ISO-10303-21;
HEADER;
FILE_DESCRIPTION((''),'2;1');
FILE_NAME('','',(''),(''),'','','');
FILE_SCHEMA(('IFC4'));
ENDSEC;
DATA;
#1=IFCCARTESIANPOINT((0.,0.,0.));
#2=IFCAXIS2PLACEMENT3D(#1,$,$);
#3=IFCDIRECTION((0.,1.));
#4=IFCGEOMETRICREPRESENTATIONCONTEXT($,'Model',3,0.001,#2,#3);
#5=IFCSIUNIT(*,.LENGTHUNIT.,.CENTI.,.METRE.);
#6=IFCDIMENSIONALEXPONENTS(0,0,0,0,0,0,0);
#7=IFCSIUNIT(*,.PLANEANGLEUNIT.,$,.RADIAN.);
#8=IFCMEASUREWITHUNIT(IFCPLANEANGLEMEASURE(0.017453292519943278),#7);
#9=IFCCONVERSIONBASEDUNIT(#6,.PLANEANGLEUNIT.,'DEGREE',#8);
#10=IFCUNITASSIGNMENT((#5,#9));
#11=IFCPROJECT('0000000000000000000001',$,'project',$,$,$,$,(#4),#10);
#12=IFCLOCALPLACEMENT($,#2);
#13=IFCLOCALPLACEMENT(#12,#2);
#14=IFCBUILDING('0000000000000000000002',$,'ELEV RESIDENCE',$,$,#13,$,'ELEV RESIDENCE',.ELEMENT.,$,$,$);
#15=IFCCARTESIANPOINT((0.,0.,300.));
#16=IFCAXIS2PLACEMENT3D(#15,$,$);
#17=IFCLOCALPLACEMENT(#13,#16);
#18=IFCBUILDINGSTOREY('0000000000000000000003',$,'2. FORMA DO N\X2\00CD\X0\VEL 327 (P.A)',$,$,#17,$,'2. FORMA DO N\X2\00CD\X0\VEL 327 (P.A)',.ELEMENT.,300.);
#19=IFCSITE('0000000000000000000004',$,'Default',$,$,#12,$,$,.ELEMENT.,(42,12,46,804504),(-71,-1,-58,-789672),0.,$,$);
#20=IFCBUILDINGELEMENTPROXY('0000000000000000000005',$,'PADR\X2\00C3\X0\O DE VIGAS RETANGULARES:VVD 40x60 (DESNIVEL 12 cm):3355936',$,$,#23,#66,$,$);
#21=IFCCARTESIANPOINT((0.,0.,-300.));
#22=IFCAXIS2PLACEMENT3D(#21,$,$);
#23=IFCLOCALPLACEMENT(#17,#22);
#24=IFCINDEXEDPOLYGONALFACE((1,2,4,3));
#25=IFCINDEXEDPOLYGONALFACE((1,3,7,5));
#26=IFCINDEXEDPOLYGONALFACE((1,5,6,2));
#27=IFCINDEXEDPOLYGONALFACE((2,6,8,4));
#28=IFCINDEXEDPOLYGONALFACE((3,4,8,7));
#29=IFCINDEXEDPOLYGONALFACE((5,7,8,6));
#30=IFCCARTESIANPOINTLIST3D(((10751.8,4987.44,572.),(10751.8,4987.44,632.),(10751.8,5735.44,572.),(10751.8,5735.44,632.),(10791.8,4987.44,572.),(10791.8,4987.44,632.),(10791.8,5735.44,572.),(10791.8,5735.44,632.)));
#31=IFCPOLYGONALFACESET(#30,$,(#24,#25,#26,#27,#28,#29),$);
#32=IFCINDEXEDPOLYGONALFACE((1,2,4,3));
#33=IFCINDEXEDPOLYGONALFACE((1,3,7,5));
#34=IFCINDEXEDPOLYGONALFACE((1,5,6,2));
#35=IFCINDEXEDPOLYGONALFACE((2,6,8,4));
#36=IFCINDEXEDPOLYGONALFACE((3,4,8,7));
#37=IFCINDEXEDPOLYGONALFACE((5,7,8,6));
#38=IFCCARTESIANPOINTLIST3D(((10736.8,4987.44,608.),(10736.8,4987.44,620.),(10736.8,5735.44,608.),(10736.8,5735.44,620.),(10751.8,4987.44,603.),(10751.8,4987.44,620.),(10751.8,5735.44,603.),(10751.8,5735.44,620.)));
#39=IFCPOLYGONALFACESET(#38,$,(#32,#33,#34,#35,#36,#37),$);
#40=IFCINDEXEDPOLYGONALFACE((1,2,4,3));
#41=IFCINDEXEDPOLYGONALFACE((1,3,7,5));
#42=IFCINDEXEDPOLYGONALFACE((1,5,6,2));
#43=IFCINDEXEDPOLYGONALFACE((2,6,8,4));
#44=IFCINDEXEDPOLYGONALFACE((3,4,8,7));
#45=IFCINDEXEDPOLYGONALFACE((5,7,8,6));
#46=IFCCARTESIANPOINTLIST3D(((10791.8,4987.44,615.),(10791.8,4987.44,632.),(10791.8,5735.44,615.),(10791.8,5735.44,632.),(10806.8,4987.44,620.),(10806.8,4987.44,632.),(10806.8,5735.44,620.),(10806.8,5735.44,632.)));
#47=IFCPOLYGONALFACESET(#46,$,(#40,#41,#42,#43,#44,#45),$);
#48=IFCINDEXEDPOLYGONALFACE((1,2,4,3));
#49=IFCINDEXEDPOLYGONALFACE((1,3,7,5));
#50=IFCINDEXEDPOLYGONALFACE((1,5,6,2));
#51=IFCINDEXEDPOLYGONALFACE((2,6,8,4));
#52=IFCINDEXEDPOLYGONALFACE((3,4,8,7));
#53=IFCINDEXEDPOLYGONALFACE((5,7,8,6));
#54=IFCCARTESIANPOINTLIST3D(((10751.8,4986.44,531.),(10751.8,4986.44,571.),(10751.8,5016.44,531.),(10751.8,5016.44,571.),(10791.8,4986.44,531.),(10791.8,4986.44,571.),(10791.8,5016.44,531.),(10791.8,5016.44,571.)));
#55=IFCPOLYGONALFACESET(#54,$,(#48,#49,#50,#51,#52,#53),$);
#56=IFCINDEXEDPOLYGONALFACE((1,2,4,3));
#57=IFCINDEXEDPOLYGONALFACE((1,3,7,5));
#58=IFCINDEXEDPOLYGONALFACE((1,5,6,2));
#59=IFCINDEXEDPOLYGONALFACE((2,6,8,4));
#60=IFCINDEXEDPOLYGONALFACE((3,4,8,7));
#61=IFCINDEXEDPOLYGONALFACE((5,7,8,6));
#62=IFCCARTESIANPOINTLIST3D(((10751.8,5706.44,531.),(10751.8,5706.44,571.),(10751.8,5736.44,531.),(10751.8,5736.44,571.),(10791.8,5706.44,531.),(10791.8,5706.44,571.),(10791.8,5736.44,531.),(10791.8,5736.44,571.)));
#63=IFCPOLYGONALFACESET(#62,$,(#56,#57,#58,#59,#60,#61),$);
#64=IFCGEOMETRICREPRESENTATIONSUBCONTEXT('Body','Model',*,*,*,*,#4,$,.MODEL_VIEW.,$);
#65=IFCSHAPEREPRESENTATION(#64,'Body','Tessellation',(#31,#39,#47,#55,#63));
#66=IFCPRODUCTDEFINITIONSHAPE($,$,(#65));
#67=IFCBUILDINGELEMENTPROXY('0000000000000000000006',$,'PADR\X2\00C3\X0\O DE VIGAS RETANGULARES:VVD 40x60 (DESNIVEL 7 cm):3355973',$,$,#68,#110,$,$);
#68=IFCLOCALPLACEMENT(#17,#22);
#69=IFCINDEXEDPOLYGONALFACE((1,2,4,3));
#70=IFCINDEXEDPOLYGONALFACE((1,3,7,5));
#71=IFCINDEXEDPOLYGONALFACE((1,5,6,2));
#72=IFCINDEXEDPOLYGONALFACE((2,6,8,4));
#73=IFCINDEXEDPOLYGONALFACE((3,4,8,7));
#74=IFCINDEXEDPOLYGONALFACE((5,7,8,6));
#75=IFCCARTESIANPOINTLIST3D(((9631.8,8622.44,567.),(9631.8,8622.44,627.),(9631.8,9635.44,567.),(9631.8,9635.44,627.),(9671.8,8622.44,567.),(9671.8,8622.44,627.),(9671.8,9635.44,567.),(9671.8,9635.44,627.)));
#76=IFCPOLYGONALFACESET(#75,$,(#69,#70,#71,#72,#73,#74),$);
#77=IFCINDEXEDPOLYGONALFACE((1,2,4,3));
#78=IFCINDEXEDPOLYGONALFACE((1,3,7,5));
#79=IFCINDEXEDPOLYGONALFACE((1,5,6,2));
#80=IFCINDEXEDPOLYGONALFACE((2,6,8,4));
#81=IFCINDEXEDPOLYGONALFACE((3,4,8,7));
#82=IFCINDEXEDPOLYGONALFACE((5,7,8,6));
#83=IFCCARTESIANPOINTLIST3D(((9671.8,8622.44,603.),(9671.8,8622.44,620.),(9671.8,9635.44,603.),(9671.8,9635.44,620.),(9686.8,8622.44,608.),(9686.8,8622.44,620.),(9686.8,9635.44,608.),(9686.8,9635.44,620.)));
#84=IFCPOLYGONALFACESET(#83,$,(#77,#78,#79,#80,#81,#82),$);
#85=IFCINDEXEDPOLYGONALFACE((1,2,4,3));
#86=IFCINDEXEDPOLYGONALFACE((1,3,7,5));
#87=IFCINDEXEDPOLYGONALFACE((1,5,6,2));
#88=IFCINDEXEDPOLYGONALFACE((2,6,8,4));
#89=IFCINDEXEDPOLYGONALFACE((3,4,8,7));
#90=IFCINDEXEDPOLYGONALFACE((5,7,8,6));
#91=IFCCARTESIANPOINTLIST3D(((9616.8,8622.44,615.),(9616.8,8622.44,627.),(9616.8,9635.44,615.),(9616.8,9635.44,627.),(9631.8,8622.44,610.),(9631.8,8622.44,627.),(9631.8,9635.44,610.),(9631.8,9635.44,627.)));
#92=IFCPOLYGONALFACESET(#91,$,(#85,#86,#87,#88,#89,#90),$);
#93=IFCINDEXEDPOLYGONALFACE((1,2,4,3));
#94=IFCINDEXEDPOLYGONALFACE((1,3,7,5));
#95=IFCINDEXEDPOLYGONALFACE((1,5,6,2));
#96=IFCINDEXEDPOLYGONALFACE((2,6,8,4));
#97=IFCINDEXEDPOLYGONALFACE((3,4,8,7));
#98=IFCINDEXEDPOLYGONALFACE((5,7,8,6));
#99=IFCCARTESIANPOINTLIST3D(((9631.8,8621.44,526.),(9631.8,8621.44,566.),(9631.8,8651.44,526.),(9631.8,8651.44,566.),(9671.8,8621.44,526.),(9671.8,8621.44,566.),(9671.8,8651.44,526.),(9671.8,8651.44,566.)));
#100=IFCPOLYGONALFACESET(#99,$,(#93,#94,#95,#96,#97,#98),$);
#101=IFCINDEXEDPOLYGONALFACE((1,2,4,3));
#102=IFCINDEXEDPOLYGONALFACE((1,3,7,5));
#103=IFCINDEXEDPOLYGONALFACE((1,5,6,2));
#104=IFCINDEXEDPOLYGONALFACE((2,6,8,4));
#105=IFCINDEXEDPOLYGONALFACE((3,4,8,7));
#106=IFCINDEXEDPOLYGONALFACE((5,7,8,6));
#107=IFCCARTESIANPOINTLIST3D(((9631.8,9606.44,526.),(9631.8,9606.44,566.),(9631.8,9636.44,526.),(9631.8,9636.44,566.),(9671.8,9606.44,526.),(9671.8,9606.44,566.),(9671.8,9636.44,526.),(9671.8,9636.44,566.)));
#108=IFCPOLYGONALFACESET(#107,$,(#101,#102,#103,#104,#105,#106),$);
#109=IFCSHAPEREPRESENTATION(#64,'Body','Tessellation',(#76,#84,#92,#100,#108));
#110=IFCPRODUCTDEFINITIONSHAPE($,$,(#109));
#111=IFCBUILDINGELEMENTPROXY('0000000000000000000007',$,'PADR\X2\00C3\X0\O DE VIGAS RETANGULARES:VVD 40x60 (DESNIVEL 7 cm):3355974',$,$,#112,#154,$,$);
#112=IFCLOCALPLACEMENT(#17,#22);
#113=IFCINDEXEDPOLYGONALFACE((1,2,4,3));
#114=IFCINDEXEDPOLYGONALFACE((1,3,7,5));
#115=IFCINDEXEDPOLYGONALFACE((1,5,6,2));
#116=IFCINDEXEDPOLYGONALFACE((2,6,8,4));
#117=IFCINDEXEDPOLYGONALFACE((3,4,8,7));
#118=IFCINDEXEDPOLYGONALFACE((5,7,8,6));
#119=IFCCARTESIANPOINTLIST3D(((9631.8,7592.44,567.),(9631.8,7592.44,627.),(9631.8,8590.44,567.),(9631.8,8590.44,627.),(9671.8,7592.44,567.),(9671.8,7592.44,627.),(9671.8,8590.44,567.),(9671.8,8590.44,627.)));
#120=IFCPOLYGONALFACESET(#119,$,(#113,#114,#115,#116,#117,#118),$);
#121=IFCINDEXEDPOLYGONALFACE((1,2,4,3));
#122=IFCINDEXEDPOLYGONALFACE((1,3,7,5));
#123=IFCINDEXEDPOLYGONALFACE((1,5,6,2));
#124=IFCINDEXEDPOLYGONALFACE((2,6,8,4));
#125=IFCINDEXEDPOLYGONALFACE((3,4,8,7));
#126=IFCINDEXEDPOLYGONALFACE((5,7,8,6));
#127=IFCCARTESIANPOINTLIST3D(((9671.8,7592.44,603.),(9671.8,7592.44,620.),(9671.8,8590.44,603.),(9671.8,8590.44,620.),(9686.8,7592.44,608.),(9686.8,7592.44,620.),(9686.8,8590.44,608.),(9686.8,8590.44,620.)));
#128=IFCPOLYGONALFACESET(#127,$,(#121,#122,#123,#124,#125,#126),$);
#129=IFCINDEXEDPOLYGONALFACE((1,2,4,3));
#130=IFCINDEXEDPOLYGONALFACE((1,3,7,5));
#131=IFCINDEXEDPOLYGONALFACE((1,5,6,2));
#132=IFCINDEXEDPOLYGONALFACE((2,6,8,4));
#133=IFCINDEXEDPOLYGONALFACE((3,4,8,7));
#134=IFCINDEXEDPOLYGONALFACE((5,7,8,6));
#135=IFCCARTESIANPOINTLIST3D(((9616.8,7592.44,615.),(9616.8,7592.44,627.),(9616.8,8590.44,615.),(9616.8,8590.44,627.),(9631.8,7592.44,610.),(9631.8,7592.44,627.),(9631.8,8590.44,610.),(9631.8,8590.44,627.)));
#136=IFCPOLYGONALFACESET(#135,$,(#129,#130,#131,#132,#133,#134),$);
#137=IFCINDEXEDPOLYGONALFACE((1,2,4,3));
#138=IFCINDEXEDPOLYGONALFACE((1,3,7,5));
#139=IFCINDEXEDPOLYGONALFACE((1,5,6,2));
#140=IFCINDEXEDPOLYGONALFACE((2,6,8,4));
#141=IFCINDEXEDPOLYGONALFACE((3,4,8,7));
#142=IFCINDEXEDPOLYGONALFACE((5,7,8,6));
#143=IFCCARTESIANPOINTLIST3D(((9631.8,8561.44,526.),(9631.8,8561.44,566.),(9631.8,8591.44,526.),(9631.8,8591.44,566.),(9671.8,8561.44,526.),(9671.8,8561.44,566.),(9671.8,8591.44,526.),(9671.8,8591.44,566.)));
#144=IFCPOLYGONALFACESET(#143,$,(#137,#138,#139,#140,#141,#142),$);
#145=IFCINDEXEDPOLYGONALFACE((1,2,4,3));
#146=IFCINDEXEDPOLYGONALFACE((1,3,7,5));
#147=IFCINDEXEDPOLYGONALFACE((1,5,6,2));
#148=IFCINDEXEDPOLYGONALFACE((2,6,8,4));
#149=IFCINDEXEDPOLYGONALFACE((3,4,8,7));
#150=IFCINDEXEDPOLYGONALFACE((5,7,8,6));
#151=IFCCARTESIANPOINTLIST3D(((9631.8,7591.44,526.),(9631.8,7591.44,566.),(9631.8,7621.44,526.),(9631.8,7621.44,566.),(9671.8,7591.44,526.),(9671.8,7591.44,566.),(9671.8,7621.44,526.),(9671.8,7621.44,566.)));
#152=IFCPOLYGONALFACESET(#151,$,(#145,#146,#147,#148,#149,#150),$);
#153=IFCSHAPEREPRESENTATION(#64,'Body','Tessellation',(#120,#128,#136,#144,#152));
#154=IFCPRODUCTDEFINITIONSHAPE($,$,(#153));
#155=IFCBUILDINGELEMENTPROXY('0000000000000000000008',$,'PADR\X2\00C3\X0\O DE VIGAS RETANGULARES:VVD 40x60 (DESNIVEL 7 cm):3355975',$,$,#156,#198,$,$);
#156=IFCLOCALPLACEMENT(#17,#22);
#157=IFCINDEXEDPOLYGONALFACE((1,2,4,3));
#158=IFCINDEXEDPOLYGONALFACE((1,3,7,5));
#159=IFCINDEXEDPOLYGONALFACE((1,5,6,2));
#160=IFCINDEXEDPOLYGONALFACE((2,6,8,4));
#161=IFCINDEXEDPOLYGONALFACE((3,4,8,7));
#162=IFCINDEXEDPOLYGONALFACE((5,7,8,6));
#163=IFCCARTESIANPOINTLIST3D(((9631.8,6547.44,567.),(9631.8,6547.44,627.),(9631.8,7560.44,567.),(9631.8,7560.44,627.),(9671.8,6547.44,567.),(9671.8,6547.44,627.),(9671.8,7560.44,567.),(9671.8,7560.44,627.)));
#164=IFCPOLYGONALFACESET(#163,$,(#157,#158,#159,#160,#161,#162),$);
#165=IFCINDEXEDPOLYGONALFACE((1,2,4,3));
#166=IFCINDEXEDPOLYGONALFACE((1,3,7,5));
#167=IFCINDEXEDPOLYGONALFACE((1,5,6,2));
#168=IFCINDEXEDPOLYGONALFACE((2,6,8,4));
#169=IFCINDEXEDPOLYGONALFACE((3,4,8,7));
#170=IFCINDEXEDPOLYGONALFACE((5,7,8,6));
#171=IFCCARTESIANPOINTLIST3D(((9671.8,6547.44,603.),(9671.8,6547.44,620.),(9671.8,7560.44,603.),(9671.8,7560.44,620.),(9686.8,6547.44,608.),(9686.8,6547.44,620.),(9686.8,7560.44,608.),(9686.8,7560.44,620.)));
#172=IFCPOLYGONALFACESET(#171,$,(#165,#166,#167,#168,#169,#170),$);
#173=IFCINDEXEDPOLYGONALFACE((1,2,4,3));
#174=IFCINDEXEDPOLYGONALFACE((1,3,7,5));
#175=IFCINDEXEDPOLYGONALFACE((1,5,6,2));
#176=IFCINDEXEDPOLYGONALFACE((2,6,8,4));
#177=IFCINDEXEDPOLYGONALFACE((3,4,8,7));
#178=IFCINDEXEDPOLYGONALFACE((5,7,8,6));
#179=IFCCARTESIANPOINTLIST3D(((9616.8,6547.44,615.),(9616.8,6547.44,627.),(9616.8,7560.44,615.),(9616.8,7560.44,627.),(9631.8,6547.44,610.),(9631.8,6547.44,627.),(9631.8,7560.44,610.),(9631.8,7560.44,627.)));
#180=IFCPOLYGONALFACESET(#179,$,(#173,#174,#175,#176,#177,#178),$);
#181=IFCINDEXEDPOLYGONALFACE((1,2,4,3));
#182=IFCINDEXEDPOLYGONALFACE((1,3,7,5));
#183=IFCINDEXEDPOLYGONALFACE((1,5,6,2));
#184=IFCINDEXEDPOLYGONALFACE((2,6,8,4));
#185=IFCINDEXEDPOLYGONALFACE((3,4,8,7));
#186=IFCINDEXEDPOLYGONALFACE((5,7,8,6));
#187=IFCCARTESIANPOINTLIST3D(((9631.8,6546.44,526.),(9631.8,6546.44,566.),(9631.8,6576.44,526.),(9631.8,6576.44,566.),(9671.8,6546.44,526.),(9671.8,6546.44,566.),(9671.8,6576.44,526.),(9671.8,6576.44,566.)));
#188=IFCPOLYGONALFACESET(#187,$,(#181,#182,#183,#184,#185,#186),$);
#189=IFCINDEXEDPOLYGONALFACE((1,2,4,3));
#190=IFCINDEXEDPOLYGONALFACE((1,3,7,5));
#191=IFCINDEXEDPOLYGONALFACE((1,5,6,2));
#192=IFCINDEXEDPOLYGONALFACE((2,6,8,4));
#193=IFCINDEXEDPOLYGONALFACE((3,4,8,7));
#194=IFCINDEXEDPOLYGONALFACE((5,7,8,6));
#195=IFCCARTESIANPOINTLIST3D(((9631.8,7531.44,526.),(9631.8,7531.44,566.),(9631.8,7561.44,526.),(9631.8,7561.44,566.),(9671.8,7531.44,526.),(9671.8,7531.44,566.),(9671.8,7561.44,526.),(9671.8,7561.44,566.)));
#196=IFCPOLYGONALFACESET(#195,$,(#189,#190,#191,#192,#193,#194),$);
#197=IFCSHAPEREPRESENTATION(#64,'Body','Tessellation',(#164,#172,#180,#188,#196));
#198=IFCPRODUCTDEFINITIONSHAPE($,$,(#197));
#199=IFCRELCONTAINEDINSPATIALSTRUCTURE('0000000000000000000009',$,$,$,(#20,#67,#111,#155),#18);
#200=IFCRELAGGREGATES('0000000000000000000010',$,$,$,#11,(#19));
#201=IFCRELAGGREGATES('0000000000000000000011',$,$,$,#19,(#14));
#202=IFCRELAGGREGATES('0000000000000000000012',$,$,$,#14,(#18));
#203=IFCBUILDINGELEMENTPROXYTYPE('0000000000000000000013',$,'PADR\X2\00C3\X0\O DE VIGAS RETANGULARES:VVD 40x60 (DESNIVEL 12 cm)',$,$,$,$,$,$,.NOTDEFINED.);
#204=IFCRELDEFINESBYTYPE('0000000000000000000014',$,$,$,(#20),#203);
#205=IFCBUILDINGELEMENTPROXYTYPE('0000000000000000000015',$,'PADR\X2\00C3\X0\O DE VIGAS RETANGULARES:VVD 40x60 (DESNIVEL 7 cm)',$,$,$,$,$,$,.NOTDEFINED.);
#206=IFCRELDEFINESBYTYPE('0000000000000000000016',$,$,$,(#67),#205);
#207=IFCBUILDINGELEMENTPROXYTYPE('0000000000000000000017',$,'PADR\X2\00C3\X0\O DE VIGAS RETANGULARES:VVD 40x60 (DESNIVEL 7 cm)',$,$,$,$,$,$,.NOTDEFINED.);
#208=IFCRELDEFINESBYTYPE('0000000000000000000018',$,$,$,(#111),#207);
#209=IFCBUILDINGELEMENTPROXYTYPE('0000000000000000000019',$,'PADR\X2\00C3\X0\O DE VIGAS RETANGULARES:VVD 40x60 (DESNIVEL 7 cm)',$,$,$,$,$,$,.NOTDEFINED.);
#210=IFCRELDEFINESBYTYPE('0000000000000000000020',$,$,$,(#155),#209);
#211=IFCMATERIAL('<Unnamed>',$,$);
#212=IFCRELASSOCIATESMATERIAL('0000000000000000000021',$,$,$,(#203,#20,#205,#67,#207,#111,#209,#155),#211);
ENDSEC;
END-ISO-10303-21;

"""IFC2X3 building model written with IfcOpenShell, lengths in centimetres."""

from ifc_helpers import new_model, entity, si_unit, converted_unit, direction, frame, frame_2d, origin, place, context, subcontext, project, spatial, polyline, rectangle, outline, extrude, source, transform, mapped, material, type_object, type_shapes, element, save


model = new_model("IFC2X3")

# Units and contexts
model_context = context("Model", 3, precision=0.001, world=origin(), true_north=direction((0.0, 1.0)))
body_context = subcontext(model_context, "Body", "Model", "MODEL_VIEW")
ifc_project = project(units=[si_unit("LENGTHUNIT", "METRE", prefix="CENTI"), converted_unit("PLANEANGLEUNIT", "DEGREE", entity("IfcPlaneAngleMeasure", 0.017453292519943278), si_unit("PLANEANGLEUNIT", "RADIAN"), dimensions=[0, 0, 0, 0, 0, 0, 0])], contexts=[model_context])

# Site, building, storey
site_placement = place(None, origin())
site = spatial("IfcSite", under=ifc_project, at=site_placement, Name="Default", CompositionType="ELEMENT", RefLatitude=(42, 12, 46, 804504), RefLongitude=(-71, -1, -58, -789672), RefElevation=0.0)
building_placement = place(site_placement, origin())
building = spatial("IfcBuilding", under=site, at=building_placement, Name="ELEV RESIDENCE", LongName="ELEV RESIDENCE", CompositionType="ELEMENT")
storey_placement = place(building_placement, frame((0.0, 0.0, 300.0)))
storey = spatial("IfcBuildingStorey", under=building, at=storey_placement, Name="2. FORMA DO NÍVEL 327 (P.A)", LongName="2. FORMA DO NÍVEL 327 (P.A)", CompositionType="ELEMENT", Elevation=300.0)

# Building element proxies
ifc_material_1 = material(Name="<Unnamed>")
building_element_proxy_type_1 = type_object("IfcBuildingElementProxyType", Name="PADRÃO DE VIGAS RETANGULARES:VVD 40x60 (DESNIVEL 12 cm)", PredefinedType="NOTDEFINED", material=ifc_material_1)
shared_shape_1 = source(origin(), body_context, "Body", "SweptSolid", [
    extrude(rectangle(XDim=748.0, YDim=40.0, at=frame_2d((0.0, 0.0), x_axis=(1.0, 0.0))), frame((10771.8, 5361.44, 572.0), z_axis=(0.0, 0.0, 1.0), x_axis=(0.0, -1.0, 0.0)), (0.0, 0.0, 1.0), 60.0),
    extrude(outline(polyline([(-7.5, -7.25), (7.5, -7.25), (7.5, 9.75), (-7.5, 4.75), (-7.5, -7.25)])), frame((10744.3, 4987.44, 612.75), z_axis=(0.0, 1.0, 0.0), x_axis=(1.0, 0.0, 0.0)), (0.0, 0.0, 1.0), 748.0),
    extrude(outline(polyline([(-7.25, -7.5), (4.75, -7.5), (9.75, 7.5), (-7.25, 7.5), (-7.25, -7.5)])), frame((10799.3, 4987.44, 624.75), z_axis=(0.0, 1.0, 0.0), x_axis=(0.0, 0.0, -1.0)), (0.0, 0.0, 1.0), 748.0),
    extrude(rectangle(XDim=30.0, YDim=40.0, at=frame_2d((0.0, 0.0), x_axis=(1.0, 0.0))), frame((10771.8, 5001.44, 531.0), z_axis=(0.0, 0.0, 1.0), x_axis=(0.0, -1.0, 0.0)), (0.0, 0.0, 1.0), 40.0),
    extrude(rectangle(XDim=30.0, YDim=40.0, at=frame_2d((0.0, 0.0), x_axis=(1.0, 0.0))), frame((10771.8, 5721.44, 531.0), z_axis=(0.0, 0.0, 1.0), x_axis=(0.0, -1.0, 0.0)), (0.0, 0.0, 1.0), 40.0),
])
type_shapes(building_element_proxy_type_1, [shared_shape_1])
proxy_1_placement = place(storey_placement, frame((0.0, 0.0, -300.0)))
element("IfcBuildingElementProxy", 1, at=proxy_1_placement, inside=storey, type_object=building_element_proxy_type_1, material=ifc_material_1, Name="PADRÃO DE VIGAS RETANGULARES:VVD 40x60 (DESNIVEL 12 cm):3355936", context=body_context, shape_type="MappedRepresentation", body=[
    mapped(shared_shape_1, transform((0.0, 0.0, 0.0), scale=1.0)),
])
building_element_proxy_type_2 = type_object("IfcBuildingElementProxyType", Name="PADRÃO DE VIGAS RETANGULARES:VVD 40x60 (DESNIVEL 7 cm)", PredefinedType="NOTDEFINED", material=ifc_material_1)
shared_shape_2 = source(origin(), body_context, "Body", "SweptSolid", [
    extrude(rectangle(XDim=1013.0, YDim=40.0, at=frame_2d((0.0, 0.0), x_axis=(1.0, 0.0))), frame((9651.8, 9128.94, 567.0), z_axis=(0.0, 0.0, 1.0), x_axis=(0.0, -1.0, 0.0)), (0.0, 0.0, 1.0), 60.0),
    extrude(outline(polyline([(-7.25, -7.5), (4.75, -7.5), (9.75, 7.5), (-7.25, 7.5), (-7.25, -7.5)])), frame((9679.3, 8622.44, 612.75), z_axis=(0.0, 1.0, 0.0), x_axis=(0.0, 0.0, -1.0)), (0.0, 0.0, 1.0), 1013.0),
    extrude(outline(polyline([(-7.5, -7.25), (7.5, -7.25), (7.5, 9.75), (-7.5, 4.75), (-7.5, -7.25)])), frame((9624.3, 8622.44, 619.75), z_axis=(0.0, 1.0, 0.0), x_axis=(1.0, 0.0, 0.0)), (0.0, 0.0, 1.0), 1013.0),
    extrude(rectangle(XDim=40.0, YDim=30.0, at=frame_2d((0.0, 0.0), x_axis=(1.0, 0.0))), frame((9651.8, 8636.44, 526.0), z_axis=(0.0, 0.0, 1.0), x_axis=(-1.0, 0.0, 0.0)), (0.0, 0.0, 1.0), 40.0),
    extrude(rectangle(XDim=40.0, YDim=30.0, at=frame_2d((0.0, 0.0), x_axis=(1.0, 0.0))), frame((9651.8, 9621.44, 526.0), z_axis=(0.0, 0.0, 1.0), x_axis=(-1.0, 0.0, 0.0)), (0.0, 0.0, 1.0), 40.0),
])
type_shapes(building_element_proxy_type_2, [shared_shape_2])
proxy_2_placement = place(storey_placement, frame((0.0, 0.0, -300.0)))
element("IfcBuildingElementProxy", 2, at=proxy_2_placement, inside=storey, type_object=building_element_proxy_type_2, material=ifc_material_1, Name="PADRÃO DE VIGAS RETANGULARES:VVD 40x60 (DESNIVEL 7 cm):3355973", context=body_context, shape_type="MappedRepresentation", body=[
    mapped(shared_shape_2, transform((0.0, 0.0, 0.0), scale=1.0)),
])
building_element_proxy_type_3 = type_object("IfcBuildingElementProxyType", Name="PADRÃO DE VIGAS RETANGULARES:VVD 40x60 (DESNIVEL 7 cm)", PredefinedType="NOTDEFINED", material=ifc_material_1)
shared_shape_3 = source(origin(), body_context, "Body", "SweptSolid", [
    extrude(rectangle(XDim=40.0, YDim=998.0, at=frame_2d((0.0, 0.0), x_axis=(1.0, 0.0))), frame((9651.8, 8091.44, 567.0)), (0.0, 0.0, 1.0), 60.0),
    extrude(outline(polyline([(-7.25, -7.5), (4.75, -7.5), (9.75, 7.5), (-7.25, 7.5), (-7.25, -7.5)])), frame((9679.3, 7592.44, 612.75), z_axis=(0.0, 1.0, 0.0), x_axis=(0.0, 0.0, -1.0)), (0.0, 0.0, 1.0), 998.0),
    extrude(outline(polyline([(-7.5, -7.25), (7.5, -7.25), (7.5, 9.75), (-7.5, 4.75), (-7.5, -7.25)])), frame((9624.3, 7592.44, 619.75), z_axis=(0.0, 1.0, 0.0), x_axis=(1.0, 0.0, 0.0)), (0.0, 0.0, 1.0), 998.0),
    extrude(rectangle(XDim=30.0, YDim=40.0, at=frame_2d((0.0, 0.0), x_axis=(1.0, 0.0))), frame((9651.8, 8576.44, 526.0), z_axis=(0.0, 0.0, 1.0), x_axis=(0.0, 1.0, 0.0)), (0.0, 0.0, 1.0), 40.0),
    extrude(rectangle(XDim=30.0, YDim=40.0, at=frame_2d((0.0, 0.0), x_axis=(1.0, 0.0))), frame((9651.8, 7606.44, 526.0), z_axis=(0.0, 0.0, 1.0), x_axis=(0.0, 1.0, 0.0)), (0.0, 0.0, 1.0), 40.0),
])
type_shapes(building_element_proxy_type_3, [shared_shape_3])
proxy_3_placement = place(storey_placement, frame((0.0, 0.0, -300.0)))
element("IfcBuildingElementProxy", 3, at=proxy_3_placement, inside=storey, type_object=building_element_proxy_type_3, material=ifc_material_1, Name="PADRÃO DE VIGAS RETANGULARES:VVD 40x60 (DESNIVEL 7 cm):3355974", context=body_context, shape_type="MappedRepresentation", body=[
    mapped(shared_shape_3, transform((0.0, 0.0, 0.0), scale=1.0)),
])
building_element_proxy_type_4 = type_object("IfcBuildingElementProxyType", Name="PADRÃO DE VIGAS RETANGULARES:VVD 40x60 (DESNIVEL 7 cm)", PredefinedType="NOTDEFINED", material=ifc_material_1)
shared_shape_4 = source(origin(), body_context, "Body", "SweptSolid", [
    extrude(rectangle(XDim=1013.0, YDim=40.0, at=frame_2d((0.0, 0.0), x_axis=(1.0, 0.0))), frame((9651.8, 7053.94, 567.0), z_axis=(0.0, 0.0, 1.0), x_axis=(0.0, -1.0, 0.0)), (0.0, 0.0, 1.0), 60.0),
    extrude(outline(polyline([(-7.25, -7.5), (4.75, -7.5), (9.75, 7.5), (-7.25, 7.5), (-7.25, -7.5)])), frame((9679.3, 6547.44, 612.75), z_axis=(0.0, 1.0, 0.0), x_axis=(0.0, 0.0, -1.0)), (0.0, 0.0, 1.0), 1013.0),
    extrude(outline(polyline([(-7.5, -7.25), (7.5, -7.25), (7.5, 9.75), (-7.5, 4.75), (-7.5, -7.25)])), frame((9624.3, 6547.44, 619.75), z_axis=(0.0, 1.0, 0.0), x_axis=(1.0, 0.0, 0.0)), (0.0, 0.0, 1.0), 1013.0),
    extrude(rectangle(XDim=40.0, YDim=30.0, at=frame_2d((0.0, 0.0), x_axis=(1.0, 0.0))), frame((9651.8, 6561.44, 526.0), z_axis=(0.0, 0.0, 1.0), x_axis=(-1.0, 0.0, 0.0)), (0.0, 0.0, 1.0), 40.0),
    extrude(rectangle(XDim=40.0, YDim=30.0, at=frame_2d((0.0, 0.0), x_axis=(1.0, 0.0))), frame((9651.8, 7546.44, 526.0), z_axis=(0.0, 0.0, 1.0), x_axis=(-1.0, 0.0, 0.0)), (0.0, 0.0, 1.0), 40.0),
])
type_shapes(building_element_proxy_type_4, [shared_shape_4])
proxy_4_placement = place(storey_placement, frame((0.0, 0.0, -300.0)))
element("IfcBuildingElementProxy", 4, at=proxy_4_placement, inside=storey, type_object=building_element_proxy_type_4, material=ifc_material_1, Name="PADRÃO DE VIGAS RETANGULARES:VVD 40x60 (DESNIVEL 7 cm):3355975", context=body_context, shape_type="MappedRepresentation", body=[
    mapped(shared_shape_4, transform((0.0, 0.0, 0.0), scale=1.0)),
])

save(model, "model.ifc")
